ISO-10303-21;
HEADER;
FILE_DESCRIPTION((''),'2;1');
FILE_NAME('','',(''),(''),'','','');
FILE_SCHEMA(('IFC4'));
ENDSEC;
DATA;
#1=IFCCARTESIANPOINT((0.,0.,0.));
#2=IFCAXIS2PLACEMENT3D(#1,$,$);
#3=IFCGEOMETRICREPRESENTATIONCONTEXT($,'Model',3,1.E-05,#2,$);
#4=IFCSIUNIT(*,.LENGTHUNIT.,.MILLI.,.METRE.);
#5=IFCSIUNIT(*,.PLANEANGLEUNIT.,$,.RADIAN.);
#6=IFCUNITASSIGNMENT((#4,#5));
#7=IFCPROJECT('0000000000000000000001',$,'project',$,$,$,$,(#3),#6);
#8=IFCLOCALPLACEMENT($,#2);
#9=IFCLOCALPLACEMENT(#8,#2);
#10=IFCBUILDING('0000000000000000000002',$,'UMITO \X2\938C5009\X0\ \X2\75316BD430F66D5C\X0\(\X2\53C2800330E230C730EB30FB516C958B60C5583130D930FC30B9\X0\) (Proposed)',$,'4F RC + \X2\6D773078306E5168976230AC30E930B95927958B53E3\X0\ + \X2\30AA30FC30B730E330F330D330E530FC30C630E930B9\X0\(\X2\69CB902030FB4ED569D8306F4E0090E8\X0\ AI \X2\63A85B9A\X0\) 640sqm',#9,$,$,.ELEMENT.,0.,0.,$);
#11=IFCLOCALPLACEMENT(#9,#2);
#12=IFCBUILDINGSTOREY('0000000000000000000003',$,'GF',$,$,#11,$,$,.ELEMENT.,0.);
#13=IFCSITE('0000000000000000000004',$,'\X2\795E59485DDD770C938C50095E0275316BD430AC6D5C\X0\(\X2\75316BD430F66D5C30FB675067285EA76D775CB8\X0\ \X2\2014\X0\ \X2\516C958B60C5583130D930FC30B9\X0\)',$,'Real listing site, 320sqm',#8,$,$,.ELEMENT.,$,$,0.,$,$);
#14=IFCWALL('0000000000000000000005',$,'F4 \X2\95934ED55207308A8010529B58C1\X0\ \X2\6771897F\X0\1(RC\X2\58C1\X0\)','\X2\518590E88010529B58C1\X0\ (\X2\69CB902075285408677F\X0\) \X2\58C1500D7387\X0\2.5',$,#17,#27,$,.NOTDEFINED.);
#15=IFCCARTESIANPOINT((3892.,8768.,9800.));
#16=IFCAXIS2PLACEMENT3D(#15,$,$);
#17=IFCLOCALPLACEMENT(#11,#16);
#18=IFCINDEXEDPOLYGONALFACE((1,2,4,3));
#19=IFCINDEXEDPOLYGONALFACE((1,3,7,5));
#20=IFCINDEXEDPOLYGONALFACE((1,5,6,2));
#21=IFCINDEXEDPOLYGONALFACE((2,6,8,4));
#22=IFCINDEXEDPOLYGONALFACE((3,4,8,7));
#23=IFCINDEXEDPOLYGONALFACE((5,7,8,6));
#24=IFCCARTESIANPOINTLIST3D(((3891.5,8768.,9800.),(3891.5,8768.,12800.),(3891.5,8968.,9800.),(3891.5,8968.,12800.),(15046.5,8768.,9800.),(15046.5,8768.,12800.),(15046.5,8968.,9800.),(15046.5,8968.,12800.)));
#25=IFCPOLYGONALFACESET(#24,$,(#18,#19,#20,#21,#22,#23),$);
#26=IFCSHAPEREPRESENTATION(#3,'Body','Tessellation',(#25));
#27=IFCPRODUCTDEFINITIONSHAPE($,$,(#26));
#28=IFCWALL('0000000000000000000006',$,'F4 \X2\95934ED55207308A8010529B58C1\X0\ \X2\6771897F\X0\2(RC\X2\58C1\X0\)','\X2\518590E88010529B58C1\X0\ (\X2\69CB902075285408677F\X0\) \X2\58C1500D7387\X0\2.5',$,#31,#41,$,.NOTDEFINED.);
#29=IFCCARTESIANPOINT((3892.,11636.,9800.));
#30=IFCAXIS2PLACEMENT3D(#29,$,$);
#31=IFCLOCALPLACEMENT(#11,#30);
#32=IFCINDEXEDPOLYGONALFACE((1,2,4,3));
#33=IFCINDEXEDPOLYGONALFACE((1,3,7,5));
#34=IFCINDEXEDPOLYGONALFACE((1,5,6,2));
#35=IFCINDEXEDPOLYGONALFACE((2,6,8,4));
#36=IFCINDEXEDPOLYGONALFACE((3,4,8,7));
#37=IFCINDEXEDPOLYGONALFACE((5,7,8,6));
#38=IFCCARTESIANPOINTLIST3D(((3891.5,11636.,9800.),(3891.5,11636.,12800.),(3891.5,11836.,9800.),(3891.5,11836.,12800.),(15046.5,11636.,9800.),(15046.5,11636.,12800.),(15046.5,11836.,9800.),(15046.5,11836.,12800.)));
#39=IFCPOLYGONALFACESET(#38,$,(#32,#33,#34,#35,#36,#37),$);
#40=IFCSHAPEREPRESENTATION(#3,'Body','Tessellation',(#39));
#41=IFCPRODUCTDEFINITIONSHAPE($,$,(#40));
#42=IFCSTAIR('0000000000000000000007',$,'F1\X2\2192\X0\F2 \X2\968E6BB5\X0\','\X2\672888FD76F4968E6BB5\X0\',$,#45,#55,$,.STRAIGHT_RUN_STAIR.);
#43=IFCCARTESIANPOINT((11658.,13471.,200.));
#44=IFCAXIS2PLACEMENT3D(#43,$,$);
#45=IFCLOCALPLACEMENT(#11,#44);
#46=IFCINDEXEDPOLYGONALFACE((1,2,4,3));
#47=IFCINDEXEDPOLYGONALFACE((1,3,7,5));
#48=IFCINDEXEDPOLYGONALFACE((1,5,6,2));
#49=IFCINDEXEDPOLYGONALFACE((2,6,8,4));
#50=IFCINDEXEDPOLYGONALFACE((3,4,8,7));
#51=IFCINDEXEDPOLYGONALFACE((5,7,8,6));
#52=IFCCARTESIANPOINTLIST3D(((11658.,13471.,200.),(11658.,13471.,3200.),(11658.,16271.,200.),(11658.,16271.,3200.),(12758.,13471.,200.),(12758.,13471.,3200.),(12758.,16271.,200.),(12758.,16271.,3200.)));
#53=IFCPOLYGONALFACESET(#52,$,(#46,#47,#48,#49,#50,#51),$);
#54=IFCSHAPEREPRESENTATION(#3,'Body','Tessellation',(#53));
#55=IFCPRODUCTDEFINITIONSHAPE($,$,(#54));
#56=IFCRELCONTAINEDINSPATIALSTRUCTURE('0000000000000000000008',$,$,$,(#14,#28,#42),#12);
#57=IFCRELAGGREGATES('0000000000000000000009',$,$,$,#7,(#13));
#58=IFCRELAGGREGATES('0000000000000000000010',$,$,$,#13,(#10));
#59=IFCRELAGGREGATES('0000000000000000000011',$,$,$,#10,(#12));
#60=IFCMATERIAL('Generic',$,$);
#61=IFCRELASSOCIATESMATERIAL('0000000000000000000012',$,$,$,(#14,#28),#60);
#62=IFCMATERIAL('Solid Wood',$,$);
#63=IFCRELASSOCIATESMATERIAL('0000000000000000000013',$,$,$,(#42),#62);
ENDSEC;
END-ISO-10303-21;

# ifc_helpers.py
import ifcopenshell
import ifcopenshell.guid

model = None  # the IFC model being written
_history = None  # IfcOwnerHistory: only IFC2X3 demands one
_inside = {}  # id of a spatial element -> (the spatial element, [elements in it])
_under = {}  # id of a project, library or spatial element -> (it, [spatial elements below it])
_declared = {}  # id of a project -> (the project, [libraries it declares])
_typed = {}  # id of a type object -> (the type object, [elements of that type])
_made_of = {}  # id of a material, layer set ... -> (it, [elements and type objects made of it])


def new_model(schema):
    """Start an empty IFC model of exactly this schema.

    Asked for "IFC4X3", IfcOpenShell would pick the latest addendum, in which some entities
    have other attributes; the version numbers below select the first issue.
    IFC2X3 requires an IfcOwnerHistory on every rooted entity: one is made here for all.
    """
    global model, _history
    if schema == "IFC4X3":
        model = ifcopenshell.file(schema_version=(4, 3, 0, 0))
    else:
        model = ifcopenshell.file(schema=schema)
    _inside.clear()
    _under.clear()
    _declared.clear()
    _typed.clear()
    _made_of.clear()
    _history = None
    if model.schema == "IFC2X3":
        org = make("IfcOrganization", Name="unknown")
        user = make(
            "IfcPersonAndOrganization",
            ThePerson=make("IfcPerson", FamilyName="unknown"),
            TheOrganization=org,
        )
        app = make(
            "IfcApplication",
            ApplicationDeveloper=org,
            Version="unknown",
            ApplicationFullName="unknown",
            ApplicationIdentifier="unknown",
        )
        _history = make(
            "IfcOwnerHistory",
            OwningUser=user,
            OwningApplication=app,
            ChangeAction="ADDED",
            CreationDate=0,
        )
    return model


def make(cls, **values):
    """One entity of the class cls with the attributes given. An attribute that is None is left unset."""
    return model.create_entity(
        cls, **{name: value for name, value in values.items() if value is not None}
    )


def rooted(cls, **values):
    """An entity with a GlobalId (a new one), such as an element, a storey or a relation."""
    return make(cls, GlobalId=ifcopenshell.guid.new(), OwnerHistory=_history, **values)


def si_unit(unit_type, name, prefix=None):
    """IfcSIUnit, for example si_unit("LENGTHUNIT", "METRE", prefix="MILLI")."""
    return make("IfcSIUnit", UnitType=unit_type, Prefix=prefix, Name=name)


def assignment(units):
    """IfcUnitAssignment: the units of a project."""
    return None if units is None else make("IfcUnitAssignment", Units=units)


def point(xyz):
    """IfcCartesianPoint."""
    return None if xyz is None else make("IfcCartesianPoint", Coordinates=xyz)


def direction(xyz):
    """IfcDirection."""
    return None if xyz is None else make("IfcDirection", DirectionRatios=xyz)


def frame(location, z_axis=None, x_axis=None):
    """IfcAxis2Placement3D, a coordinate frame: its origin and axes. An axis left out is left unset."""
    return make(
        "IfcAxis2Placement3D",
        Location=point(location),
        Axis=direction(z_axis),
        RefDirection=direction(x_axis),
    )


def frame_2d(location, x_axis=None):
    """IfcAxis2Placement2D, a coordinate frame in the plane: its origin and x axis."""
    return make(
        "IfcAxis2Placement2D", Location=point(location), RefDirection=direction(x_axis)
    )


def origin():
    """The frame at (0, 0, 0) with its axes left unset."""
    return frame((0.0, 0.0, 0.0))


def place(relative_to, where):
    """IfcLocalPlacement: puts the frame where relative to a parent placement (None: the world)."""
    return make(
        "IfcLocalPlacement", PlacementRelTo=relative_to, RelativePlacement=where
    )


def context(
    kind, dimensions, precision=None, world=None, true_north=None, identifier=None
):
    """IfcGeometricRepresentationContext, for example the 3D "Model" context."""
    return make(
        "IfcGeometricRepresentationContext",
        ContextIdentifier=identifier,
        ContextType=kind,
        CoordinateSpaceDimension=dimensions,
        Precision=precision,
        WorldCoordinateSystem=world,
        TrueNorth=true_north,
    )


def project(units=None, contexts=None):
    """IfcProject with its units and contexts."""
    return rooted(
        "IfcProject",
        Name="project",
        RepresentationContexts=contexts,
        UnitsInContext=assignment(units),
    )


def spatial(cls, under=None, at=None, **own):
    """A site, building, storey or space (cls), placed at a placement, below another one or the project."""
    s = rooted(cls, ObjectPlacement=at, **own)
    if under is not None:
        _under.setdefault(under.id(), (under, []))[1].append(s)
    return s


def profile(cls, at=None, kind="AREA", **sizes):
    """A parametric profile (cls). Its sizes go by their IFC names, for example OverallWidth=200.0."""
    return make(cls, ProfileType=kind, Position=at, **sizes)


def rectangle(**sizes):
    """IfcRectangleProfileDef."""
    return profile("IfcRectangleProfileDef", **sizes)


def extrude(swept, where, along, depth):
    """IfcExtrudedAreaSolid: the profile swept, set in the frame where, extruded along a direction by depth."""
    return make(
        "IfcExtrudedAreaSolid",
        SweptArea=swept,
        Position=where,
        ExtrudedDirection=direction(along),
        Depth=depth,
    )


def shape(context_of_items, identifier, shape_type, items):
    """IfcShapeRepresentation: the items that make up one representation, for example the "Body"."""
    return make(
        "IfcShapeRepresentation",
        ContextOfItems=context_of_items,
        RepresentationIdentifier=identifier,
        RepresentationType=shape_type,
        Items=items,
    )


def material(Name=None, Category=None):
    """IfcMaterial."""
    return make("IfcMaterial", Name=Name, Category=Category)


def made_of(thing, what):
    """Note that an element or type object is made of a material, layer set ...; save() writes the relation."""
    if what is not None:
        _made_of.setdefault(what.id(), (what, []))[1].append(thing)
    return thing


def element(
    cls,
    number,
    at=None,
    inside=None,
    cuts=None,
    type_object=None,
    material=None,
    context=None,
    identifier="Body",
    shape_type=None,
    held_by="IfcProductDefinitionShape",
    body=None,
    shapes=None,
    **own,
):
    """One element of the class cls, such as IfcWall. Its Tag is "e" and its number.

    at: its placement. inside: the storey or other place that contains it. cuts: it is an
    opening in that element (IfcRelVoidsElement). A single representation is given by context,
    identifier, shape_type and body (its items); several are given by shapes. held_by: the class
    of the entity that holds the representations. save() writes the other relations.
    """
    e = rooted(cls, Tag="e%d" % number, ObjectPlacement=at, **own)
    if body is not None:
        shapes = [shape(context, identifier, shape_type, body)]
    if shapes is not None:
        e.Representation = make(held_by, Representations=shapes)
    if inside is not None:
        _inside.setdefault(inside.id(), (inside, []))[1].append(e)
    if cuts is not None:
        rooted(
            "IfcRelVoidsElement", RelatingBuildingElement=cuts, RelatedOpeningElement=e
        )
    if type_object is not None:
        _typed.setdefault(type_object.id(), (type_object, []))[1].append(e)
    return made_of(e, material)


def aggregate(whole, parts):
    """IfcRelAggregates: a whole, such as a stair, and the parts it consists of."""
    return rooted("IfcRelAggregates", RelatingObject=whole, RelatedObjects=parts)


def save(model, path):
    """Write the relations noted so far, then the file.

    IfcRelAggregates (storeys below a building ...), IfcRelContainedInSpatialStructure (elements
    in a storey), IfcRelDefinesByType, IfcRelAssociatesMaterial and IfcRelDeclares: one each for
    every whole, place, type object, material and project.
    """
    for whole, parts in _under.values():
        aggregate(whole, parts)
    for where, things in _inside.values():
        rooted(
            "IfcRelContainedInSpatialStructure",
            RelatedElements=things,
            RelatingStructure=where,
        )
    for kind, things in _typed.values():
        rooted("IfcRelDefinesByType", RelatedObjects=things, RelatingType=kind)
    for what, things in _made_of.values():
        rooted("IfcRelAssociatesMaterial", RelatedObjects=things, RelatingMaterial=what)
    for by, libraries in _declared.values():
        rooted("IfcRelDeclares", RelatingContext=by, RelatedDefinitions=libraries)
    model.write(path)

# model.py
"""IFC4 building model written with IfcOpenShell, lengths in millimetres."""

from ifc_helpers import new_model, si_unit, frame, frame_2d, origin, place, context, project, spatial, rectangle, extrude, material, element, save


model = new_model("IFC4")

# Units and contexts
model_context = context("Model", 3, precision=1e-05, world=origin())
ifc_project = project(units=[si_unit("LENGTHUNIT", "METRE", prefix="MILLI"), si_unit("PLANEANGLEUNIT", "RADIAN")], contexts=[model_context])

# Site, building, storey
site_placement = place(None, origin())
site = spatial("IfcSite", under=ifc_project, at=site_placement, Name="神奈川県鎌倉市由比ガ浜(由比ヶ浜・材木座海岸 — 公開情報ベース)", ObjectType="Real listing site, 320sqm", CompositionType="ELEMENT", RefElevation=0.0)
building_placement = place(site_placement, origin())
building = spatial("IfcBuilding", under=site, at=building_placement, Name="UMITO 鎌倉 由比ヶ浜(参考モデル・公開情報ベース) (Proposed)", ObjectType="4F RC + 海への全面ガラス大開口 + オーシャンビューテラス(構造・仕様は一部 AI 推定) 640sqm", CompositionType="ELEMENT", ElevationOfRefHeight=0.0, ElevationOfTerrain=0.0)
storey_placement = place(building_placement, origin())
storey = spatial("IfcBuildingStorey", under=building, at=storey_placement, Name="GF", CompositionType="ELEMENT", Elevation=0.0)

# Shared definitions
ifc_material_1 = material(Name="Generic")

# Walls
wall_1_placement = place(storey_placement, frame((3892.0, 8768.0, 9800.0)))
element("IfcWall", 1, at=wall_1_placement, inside=storey, material=ifc_material_1, Name="F4 間仕切り耐力壁 東西1(RC壁)", Description="内部耐力壁 (構造用合板) 壁倍率2.5", PredefinedType="NOTDEFINED", context=model_context, shape_type="SweptSolid", body=[
    extrude(rectangle(XDim=11155.0, YDim=200.0, at=frame_2d((5577.0, 100.0))), frame((3892.0, 8768.0, 9800.0)), (0.0, 0.0, 1.0), 3000.0),
])
wall_2_placement = place(storey_placement, frame((3892.0, 11636.0, 9800.0)))
element("IfcWall", 2, at=wall_2_placement, inside=storey, material=ifc_material_1, Name="F4 間仕切り耐力壁 東西2(RC壁)", Description="内部耐力壁 (構造用合板) 壁倍率2.5", PredefinedType="NOTDEFINED", context=model_context, shape_type="SweptSolid", body=[
    extrude(rectangle(XDim=11155.0, YDim=200.0, at=frame_2d((5577.0, 100.0))), frame((3892.0, 11636.0, 9800.0)), (0.0, 0.0, 1.0), 3000.0),
])

# Stair
ifc_material_2 = material(Name="Solid Wood")
stair_placement = place(storey_placement, frame((11658.0, 13471.0, 200.0)))
element("IfcStair", 3, at=stair_placement, inside=storey, material=ifc_material_2, Name="F1→F2 階段", Description="木製直階段", PredefinedType="STRAIGHT_RUN_STAIR", context=model_context, shape_type="SweptSolid", body=[
    extrude(rectangle(XDim=1100.0, YDim=2800.0, at=frame_2d((550.0, 1400.0))), frame((11658.0, 13471.0, 200.0)), (0.0, 0.0, 1.0), 3000.0),
])

save(model, "model.ifc")
